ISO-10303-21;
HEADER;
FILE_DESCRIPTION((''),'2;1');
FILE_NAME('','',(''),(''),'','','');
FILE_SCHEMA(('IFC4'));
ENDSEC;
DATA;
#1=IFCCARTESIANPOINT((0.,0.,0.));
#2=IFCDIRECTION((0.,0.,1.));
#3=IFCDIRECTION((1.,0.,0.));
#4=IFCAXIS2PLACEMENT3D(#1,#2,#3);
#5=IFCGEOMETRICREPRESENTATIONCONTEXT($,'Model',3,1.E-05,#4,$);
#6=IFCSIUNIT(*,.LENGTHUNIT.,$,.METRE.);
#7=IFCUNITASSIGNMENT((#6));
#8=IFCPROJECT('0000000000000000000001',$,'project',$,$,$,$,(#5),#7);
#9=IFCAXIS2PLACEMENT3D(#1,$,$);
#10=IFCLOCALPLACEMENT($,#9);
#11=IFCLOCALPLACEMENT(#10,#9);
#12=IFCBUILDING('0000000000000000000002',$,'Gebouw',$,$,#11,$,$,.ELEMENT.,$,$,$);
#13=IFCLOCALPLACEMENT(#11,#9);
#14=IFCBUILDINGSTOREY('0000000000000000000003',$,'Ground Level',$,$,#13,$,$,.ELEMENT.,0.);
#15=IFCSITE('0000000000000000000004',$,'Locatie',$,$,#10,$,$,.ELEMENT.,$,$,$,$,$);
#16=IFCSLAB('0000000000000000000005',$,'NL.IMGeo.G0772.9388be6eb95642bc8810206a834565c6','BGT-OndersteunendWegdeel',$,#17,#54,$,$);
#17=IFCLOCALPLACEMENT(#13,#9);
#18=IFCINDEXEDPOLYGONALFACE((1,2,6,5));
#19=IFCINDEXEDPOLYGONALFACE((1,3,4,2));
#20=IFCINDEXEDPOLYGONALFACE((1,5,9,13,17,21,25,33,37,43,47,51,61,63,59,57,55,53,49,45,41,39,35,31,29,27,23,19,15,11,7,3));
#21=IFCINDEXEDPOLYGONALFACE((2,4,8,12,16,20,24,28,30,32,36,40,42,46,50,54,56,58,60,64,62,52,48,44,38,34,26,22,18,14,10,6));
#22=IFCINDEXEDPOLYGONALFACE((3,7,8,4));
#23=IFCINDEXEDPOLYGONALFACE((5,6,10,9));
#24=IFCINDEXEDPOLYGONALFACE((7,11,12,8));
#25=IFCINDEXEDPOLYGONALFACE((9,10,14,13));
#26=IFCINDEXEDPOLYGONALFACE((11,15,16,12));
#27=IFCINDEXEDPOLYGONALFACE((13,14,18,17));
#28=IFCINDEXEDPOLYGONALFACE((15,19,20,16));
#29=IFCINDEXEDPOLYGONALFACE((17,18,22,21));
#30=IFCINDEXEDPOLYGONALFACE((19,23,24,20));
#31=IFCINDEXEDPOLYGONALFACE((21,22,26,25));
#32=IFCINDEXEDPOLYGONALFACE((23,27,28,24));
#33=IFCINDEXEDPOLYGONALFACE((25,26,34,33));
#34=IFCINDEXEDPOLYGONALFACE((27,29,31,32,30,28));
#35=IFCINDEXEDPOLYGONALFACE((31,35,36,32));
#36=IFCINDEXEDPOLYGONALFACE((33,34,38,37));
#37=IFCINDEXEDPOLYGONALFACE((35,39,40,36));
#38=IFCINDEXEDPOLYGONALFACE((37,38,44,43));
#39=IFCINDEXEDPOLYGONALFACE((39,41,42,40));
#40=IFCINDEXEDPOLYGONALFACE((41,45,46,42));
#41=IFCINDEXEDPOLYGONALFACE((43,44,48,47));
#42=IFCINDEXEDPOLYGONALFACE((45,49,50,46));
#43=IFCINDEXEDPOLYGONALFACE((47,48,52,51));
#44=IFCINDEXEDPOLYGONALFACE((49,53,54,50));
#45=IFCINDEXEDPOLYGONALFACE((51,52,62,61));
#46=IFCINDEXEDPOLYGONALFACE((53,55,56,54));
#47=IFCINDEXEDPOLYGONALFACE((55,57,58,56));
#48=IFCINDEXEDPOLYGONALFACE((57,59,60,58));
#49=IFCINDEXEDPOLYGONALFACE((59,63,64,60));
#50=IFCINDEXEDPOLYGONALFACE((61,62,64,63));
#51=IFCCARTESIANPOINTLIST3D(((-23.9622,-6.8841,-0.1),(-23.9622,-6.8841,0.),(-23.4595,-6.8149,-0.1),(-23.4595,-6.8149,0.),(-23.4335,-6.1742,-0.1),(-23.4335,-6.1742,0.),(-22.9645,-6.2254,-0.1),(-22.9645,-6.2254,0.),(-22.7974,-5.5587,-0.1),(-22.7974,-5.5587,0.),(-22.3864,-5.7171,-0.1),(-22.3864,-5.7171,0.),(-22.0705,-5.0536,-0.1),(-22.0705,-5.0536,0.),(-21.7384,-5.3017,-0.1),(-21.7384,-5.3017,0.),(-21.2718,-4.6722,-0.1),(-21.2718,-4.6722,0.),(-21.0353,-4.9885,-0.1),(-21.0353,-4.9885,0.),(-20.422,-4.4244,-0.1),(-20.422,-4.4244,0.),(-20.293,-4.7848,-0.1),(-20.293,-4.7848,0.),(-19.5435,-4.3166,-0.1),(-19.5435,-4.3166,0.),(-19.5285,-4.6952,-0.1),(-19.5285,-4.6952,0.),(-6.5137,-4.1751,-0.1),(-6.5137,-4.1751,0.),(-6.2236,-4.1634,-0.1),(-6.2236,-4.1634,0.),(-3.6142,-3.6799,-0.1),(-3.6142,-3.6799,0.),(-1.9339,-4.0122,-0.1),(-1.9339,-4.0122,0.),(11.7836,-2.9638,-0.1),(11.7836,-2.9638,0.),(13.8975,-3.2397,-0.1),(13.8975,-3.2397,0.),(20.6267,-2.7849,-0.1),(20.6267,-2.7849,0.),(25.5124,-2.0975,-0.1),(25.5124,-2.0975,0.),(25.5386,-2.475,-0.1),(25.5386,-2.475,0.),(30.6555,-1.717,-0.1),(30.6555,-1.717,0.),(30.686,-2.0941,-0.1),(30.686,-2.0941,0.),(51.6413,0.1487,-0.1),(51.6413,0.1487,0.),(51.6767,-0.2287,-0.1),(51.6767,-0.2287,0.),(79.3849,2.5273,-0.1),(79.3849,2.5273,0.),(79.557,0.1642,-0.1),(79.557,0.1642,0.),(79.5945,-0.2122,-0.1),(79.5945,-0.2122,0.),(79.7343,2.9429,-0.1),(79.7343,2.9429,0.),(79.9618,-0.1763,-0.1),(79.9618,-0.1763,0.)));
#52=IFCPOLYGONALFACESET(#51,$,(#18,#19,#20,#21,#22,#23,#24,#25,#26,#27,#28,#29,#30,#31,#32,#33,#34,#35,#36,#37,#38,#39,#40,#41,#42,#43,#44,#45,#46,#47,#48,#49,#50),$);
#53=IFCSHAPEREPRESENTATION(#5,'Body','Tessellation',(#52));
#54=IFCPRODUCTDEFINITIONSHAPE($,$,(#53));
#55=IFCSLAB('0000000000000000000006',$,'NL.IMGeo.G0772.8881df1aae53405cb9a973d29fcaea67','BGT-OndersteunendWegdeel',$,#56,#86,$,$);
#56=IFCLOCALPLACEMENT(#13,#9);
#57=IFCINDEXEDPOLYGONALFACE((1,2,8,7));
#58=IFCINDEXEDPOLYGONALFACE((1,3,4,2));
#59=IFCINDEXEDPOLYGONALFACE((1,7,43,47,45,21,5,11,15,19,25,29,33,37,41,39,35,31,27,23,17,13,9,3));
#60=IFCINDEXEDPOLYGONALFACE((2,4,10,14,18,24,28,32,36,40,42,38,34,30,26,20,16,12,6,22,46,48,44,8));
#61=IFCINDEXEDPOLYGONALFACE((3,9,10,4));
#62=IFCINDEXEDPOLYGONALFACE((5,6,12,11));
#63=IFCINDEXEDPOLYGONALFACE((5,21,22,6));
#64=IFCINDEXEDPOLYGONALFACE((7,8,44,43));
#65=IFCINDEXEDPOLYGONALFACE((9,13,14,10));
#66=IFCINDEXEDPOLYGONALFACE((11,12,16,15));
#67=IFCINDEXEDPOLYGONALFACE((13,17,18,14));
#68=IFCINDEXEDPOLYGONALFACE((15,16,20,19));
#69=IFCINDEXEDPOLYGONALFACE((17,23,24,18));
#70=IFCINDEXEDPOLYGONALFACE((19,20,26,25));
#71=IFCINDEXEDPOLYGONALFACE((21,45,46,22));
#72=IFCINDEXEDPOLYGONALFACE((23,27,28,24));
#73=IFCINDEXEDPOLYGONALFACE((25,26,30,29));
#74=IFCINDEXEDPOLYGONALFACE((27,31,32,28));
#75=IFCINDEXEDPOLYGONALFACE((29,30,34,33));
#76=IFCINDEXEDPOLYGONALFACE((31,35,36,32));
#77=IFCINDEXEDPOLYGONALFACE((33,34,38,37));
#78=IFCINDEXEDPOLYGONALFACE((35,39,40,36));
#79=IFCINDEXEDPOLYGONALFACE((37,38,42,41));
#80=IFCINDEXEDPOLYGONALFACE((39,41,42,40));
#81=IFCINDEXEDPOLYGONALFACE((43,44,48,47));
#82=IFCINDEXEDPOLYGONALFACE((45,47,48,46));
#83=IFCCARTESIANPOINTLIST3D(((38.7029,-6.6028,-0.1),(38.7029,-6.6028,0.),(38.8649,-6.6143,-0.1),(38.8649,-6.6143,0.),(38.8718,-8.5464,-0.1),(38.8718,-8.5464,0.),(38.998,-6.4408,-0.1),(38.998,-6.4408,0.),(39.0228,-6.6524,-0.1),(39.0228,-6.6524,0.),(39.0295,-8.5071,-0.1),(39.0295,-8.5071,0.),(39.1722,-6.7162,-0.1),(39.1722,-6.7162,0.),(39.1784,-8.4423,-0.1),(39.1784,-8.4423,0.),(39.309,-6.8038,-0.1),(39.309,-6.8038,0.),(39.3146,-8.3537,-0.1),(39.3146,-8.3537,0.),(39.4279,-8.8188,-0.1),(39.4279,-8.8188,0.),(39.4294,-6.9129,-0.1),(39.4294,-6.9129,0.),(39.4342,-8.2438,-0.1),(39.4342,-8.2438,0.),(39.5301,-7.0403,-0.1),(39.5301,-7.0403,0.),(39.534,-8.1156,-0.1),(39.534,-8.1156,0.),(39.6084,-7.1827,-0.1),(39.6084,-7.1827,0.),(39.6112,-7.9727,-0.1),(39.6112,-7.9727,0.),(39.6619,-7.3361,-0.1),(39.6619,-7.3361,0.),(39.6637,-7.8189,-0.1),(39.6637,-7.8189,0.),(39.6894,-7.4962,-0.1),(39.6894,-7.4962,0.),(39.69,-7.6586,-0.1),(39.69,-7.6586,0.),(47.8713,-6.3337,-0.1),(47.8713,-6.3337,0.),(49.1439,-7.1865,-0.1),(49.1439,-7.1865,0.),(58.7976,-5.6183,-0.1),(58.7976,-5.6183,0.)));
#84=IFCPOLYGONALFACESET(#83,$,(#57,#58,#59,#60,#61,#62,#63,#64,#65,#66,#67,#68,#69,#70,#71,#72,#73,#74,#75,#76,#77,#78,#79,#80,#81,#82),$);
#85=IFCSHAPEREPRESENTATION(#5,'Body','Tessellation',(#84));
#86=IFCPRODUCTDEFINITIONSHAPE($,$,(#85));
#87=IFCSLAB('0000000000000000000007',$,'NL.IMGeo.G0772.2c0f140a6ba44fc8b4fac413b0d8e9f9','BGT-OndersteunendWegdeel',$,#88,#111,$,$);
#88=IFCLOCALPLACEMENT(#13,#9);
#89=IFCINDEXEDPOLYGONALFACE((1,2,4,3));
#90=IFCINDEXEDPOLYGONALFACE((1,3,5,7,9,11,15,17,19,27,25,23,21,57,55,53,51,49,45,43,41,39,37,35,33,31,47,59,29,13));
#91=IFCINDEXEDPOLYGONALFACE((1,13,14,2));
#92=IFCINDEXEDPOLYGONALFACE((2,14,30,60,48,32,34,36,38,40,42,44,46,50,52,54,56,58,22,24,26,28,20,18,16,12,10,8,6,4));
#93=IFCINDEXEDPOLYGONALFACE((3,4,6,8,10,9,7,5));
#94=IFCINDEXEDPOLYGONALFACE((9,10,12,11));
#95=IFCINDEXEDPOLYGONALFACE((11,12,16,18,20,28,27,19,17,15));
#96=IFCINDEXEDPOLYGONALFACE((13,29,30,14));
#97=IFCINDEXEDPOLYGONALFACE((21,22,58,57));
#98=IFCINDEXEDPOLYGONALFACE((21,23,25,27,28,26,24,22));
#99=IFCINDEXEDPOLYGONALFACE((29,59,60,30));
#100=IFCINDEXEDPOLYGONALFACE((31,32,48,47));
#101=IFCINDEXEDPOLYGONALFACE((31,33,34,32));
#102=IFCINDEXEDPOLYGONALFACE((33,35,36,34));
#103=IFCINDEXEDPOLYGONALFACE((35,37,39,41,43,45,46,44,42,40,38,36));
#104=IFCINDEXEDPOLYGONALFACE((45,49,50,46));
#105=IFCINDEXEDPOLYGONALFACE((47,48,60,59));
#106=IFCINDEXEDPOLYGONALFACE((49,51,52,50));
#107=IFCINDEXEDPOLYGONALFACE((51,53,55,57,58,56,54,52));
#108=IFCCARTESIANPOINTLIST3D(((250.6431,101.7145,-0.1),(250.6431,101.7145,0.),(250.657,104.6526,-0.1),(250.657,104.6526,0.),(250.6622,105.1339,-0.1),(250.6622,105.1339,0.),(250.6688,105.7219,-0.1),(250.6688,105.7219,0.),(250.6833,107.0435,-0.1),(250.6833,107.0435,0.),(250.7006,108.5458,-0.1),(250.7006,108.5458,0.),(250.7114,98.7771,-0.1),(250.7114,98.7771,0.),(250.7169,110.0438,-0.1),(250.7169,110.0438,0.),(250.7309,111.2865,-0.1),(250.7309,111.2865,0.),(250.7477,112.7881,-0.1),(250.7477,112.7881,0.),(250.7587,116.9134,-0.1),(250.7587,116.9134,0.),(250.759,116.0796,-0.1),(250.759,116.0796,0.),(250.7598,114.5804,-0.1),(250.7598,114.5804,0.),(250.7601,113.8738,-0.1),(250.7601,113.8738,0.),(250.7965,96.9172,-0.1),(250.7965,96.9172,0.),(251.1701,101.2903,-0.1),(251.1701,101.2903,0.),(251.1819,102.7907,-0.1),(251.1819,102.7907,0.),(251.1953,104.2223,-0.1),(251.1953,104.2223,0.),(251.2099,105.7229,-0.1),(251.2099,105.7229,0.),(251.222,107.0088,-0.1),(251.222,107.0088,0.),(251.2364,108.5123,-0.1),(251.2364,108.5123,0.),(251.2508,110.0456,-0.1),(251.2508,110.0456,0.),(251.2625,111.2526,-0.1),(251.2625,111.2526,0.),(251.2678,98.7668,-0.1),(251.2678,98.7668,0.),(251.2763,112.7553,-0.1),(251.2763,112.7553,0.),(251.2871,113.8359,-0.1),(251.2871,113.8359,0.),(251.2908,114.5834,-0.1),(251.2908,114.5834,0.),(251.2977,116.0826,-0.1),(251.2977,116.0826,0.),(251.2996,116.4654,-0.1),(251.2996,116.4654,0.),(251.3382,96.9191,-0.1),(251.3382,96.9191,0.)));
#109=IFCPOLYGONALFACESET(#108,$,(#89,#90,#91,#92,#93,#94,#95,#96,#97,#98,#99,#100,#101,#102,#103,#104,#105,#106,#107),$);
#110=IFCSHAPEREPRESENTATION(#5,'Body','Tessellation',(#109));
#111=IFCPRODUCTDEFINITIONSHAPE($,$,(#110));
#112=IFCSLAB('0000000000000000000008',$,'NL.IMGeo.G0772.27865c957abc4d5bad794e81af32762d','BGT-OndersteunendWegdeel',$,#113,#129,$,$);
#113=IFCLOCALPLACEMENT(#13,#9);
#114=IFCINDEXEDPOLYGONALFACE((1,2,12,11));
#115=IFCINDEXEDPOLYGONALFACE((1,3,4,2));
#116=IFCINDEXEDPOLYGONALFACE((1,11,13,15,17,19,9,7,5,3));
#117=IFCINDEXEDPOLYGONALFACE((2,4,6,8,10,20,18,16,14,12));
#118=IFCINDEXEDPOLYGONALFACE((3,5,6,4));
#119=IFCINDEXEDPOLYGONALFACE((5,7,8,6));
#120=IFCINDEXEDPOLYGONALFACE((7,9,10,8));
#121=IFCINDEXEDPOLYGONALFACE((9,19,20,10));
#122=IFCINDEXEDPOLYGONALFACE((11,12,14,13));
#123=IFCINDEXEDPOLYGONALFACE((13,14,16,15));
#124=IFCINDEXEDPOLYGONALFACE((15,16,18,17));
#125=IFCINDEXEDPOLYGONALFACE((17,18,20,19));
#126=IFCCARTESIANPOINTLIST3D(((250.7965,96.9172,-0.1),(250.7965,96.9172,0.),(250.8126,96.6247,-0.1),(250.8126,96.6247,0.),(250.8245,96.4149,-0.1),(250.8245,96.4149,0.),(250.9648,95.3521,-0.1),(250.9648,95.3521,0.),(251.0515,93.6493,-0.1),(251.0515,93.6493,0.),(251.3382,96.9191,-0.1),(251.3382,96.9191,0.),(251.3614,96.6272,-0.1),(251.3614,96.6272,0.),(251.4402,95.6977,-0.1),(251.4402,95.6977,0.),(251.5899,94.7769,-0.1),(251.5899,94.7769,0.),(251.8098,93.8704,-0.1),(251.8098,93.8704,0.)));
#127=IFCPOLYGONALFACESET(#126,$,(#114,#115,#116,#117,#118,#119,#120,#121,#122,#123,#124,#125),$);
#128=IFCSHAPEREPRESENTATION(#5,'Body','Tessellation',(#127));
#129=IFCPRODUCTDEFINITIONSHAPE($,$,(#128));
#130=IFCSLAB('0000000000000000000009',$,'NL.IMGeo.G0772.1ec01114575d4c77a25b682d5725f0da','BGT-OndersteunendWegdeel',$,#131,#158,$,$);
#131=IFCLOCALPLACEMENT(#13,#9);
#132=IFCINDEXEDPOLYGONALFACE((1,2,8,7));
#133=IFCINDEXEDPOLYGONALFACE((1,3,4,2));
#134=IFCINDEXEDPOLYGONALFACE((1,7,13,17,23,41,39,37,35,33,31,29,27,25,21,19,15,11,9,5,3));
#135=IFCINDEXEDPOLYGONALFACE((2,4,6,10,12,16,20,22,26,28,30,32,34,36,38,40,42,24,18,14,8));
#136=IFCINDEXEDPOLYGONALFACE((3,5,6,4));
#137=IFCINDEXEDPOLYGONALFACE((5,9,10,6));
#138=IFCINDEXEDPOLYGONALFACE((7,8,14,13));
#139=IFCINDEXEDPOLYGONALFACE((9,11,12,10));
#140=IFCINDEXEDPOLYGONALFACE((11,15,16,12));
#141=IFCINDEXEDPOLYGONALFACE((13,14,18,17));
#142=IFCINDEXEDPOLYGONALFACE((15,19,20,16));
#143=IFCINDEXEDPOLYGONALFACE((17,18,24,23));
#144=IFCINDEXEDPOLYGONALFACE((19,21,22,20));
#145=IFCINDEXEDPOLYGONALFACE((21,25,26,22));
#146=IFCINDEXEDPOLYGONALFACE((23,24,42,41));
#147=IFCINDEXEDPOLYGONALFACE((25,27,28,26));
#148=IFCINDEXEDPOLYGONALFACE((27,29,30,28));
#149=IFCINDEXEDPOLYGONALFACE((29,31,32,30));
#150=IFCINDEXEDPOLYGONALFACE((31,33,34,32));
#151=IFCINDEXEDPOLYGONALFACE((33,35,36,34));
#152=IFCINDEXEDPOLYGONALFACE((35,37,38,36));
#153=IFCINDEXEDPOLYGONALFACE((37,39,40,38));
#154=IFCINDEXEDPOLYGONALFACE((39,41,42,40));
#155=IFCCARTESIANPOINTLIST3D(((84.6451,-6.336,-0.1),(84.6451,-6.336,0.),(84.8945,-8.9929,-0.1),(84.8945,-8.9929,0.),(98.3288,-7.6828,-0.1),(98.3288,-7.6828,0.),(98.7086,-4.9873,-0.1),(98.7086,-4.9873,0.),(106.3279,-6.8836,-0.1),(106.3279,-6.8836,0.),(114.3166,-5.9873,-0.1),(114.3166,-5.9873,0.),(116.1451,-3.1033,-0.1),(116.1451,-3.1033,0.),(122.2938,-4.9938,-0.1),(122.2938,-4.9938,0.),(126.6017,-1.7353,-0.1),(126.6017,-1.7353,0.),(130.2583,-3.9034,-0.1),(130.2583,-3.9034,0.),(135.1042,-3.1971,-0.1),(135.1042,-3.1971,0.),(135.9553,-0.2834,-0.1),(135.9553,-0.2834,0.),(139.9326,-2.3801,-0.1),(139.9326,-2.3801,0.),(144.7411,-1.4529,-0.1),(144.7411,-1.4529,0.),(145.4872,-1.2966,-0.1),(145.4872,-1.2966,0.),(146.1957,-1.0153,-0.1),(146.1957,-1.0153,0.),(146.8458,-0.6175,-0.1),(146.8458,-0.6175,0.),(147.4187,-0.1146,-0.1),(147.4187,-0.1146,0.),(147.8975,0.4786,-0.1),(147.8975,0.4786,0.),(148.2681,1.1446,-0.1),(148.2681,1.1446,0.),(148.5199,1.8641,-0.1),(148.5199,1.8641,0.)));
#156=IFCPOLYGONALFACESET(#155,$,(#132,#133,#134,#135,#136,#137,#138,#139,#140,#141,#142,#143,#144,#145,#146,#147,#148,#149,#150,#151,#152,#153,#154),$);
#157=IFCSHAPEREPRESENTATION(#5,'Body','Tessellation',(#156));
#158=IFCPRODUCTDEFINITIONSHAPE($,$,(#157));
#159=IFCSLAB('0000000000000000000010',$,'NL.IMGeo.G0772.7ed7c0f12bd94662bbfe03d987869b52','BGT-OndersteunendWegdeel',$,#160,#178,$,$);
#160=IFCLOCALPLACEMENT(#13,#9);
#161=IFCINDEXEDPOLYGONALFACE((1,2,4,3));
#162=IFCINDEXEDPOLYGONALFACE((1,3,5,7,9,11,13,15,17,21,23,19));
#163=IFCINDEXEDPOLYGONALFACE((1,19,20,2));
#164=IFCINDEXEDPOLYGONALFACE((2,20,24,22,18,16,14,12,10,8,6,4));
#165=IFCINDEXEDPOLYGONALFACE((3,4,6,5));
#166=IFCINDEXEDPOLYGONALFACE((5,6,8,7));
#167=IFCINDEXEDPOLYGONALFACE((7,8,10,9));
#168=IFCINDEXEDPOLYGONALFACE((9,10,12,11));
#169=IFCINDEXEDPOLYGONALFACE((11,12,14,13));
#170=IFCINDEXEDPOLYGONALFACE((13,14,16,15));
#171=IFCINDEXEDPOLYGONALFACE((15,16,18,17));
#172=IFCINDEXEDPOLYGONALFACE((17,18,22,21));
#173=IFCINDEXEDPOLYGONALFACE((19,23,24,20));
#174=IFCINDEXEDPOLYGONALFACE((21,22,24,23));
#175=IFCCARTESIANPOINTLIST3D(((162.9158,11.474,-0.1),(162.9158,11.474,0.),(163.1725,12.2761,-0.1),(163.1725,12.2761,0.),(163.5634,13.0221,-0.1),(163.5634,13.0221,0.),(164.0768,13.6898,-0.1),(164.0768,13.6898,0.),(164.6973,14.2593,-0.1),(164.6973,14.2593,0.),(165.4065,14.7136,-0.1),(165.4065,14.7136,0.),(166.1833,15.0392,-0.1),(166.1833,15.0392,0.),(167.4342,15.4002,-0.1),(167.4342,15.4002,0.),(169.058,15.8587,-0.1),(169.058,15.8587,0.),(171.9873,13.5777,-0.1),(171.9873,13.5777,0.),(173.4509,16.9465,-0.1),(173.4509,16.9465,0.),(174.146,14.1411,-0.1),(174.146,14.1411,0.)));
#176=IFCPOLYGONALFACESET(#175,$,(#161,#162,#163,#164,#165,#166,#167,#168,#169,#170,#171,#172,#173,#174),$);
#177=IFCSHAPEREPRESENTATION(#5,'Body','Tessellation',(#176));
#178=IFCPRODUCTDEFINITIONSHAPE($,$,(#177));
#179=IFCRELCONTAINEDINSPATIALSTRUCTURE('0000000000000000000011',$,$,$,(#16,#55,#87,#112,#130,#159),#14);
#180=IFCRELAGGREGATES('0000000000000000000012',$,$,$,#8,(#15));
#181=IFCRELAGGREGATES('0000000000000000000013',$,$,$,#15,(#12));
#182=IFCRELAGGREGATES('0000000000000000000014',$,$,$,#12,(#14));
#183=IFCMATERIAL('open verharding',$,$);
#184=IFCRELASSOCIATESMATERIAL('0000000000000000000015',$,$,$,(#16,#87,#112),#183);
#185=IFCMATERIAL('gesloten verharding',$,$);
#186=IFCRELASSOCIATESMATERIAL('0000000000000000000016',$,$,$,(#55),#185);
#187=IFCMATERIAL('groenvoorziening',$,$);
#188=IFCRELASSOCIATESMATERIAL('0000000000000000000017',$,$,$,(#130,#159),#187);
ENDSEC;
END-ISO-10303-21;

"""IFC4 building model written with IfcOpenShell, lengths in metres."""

from ifc_helpers import new_model, si_unit, frame, origin, origin_with_axes, place, context, project, spatial, polyline, outline, extrude, material, element, save


model = new_model("IFC4")

# Units and contexts
model_context = context("Model", 3, precision=1e-05, world=origin_with_axes())
ifc_project = project(units=[si_unit("LENGTHUNIT", "METRE")], contexts=[model_context])

# Site, building, storey
site_placement = place(None, origin())
site = spatial("IfcSite", under=ifc_project, at=site_placement, Name="Locatie", CompositionType="ELEMENT")
building_placement = place(site_placement, origin())
building = spatial("IfcBuilding", under=site, at=building_placement, Name="Gebouw", CompositionType="ELEMENT")
storey_placement = place(building_placement, origin())
storey = spatial("IfcBuildingStorey", under=building, at=storey_placement, Name="Ground Level", CompositionType="ELEMENT", Elevation=0.0)

# Slabs
ifc_material_1 = material(Name="open verharding")
ifc_material_2 = material(Name="groenvoorziening")
slab_1_placement = place(storey_placement, origin())
element("IfcSlab", 1, at=slab_1_placement, inside=storey, material=ifc_material_1, Name="NL.IMGeo.G0772.9388be6eb95642bc8810206a834565c6", Description="BGT-OndersteunendWegdeel", context=model_context, shape_type="SweptSolid", body=[
    extrude(outline(polyline([(51.6413, 0.1487), (79.7343, 2.9429), (79.9618, -0.1763), (79.5945, -0.2122), (79.557, 0.1642), (79.3849, 2.5273), (51.6767, -0.2287), (30.686, -2.0941), (25.5386, -2.475), (20.6267, -2.7849), (13.8975, -3.2397), (-1.9339, -4.0122), (-6.2236, -4.1634), (-6.5137, -4.1751), (-19.5285, -4.6952), (-20.293, -4.7848), (-21.0353, -4.9885), (-21.7384, -5.3017), (-22.3864, -5.7171), (-22.9645, -6.2254), (-23.4595, -6.8149), (-23.9622, -6.8841), (-23.4335, -6.1742), (-22.7974, -5.5587), (-22.0705, -5.0536), (-21.2718, -4.6722), (-20.422, -4.4244), (-19.5435, -4.3166), (-3.6142, -3.6799), (11.7836, -2.9638), (25.5124, -2.0975), (30.6555, -1.717), (51.6413, 0.1487)])), frame((0.0, 0.0, -0.1), z_axis=(0.0, 0.0, 1.0), x_axis=(1.0, 0.0, 0.0)), (0.0, 0.0, 1.0), 0.1),
])
ifc_material_3 = material(Name="gesloten verharding")
slab_2_placement = place(storey_placement, origin())
element("IfcSlab", 2, at=slab_2_placement, inside=storey, material=ifc_material_3, Name="NL.IMGeo.G0772.8881df1aae53405cb9a973d29fcaea67", Description="BGT-OndersteunendWegdeel", context=model_context, shape_type="SweptSolid", body=[
    extrude(outline(polyline([(38.998, -6.4408), (47.8713, -6.3337), (58.7976, -5.6183), (49.1439, -7.1865), (39.4279, -8.8188), (38.8718, -8.5464), (39.0295, -8.5071), (39.1784, -8.4423), (39.3146, -8.3537), (39.4342, -8.2438), (39.534, -8.1156), (39.6112, -7.9727), (39.6637, -7.8189), (39.69, -7.6586), (39.6894, -7.4962), (39.6619, -7.3361), (39.6084, -7.1827), (39.5301, -7.0403), (39.4294, -6.9129), (39.309, -6.8038), (39.1722, -6.7162), (39.0228, -6.6524), (38.8649, -6.6143), (38.7029, -6.6028), (38.998, -6.4408)])), frame((0.0, 0.0, -0.1), z_axis=(0.0, 0.0, 1.0), x_axis=(1.0, 0.0, 0.0)), (0.0, 0.0, 1.0), 0.1),
])
slab_3_placement = place(storey_placement, origin())
element("IfcSlab", 3, at=slab_3_placement, inside=storey, material=ifc_material_1, Name="NL.IMGeo.G0772.2c0f140a6ba44fc8b4fac413b0d8e9f9", Description="BGT-OndersteunendWegdeel", context=model_context, shape_type="SweptSolid", body=[
    extrude(outline(polyline([(251.2977, 116.0826), (251.2908, 114.5834), (251.2871, 113.8359), (251.2763, 112.7553), (251.2625, 111.2526), (251.2508, 110.0456), (251.2364, 108.5123), (251.222, 107.0088), (251.2099, 105.7229), (251.1953, 104.2223), (251.1819, 102.7907), (251.1701, 101.2903), (251.2678, 98.7668), (251.3382, 96.9191), (250.7965, 96.9172), (250.7114, 98.7771), (250.6431, 101.7145), (250.657, 104.6526), (250.6622, 105.1339), (250.6688, 105.7219), (250.6833, 107.0435), (250.7006, 108.5458), (250.7169, 110.0438), (250.7309, 111.2865), (250.7477, 112.7881), (250.7601, 113.8738), (250.7598, 114.5804), (250.759, 116.0796), (250.7587, 116.9134), (251.2996, 116.4654), (251.2977, 116.0826)])), frame((0.0, 0.0, -0.1), z_axis=(0.0, 0.0, 1.0), x_axis=(1.0, 0.0, 0.0)), (0.0, 0.0, 1.0), 0.1),
])
slab_4_placement = place(storey_placement, origin())
element("IfcSlab", 4, at=slab_4_placement, inside=storey, material=ifc_material_1, Name="NL.IMGeo.G0772.27865c957abc4d5bad794e81af32762d", Description="BGT-OndersteunendWegdeel", context=model_context, shape_type="SweptSolid", body=[
    extrude(outline(polyline([(251.4402, 95.6977), (251.5899, 94.7769), (251.8098, 93.8704), (251.0515, 93.6493), (250.9648, 95.3521), (250.8245, 96.4149), (250.8126, 96.6247), (250.7965, 96.9172), (251.3382, 96.9191), (251.3614, 96.6272), (251.4402, 95.6977)])), frame((0.0, 0.0, -0.1), z_axis=(0.0, 0.0, 1.0), x_axis=(1.0, 0.0, 0.0)), (0.0, 0.0, 1.0), 0.1),
])
slab_5_placement = place(storey_placement, origin())
element("IfcSlab", 5, at=slab_5_placement, inside=storey, material=ifc_material_2, Name="NL.IMGeo.G0772.1ec01114575d4c77a25b682d5725f0da", Description="BGT-OndersteunendWegdeel", context=model_context, shape_type="SweptSolid", body=[
    extrude(outline(polyline([(126.6017, -1.7353), (135.9553, -0.2834), (148.5199, 1.8641), (148.2681, 1.1446), (147.8975, 0.4786), (147.4187, -0.1146), (146.8458, -0.6175), (146.1957, -1.0153), (145.4872, -1.2966), (144.7411, -1.4529), (139.9326, -2.3801), (135.1042, -3.1971), (130.2583, -3.9034), (122.2938, -4.9938), (114.3166, -5.9873), (106.3279, -6.8836), (98.3288, -7.6828), (84.8945, -8.9929), (84.6451, -6.336), (98.7086, -4.9873), (116.1451, -3.1033), (126.6017, -1.7353)])), frame((0.0, 0.0, -0.1), z_axis=(0.0, 0.0, 1.0), x_axis=(1.0, 0.0, 0.0)), (0.0, 0.0, 1.0), 0.1),
])
slab_6_placement = place(storey_placement, origin())
element("IfcSlab", 6, at=slab_6_placement, inside=storey, material=ifc_material_2, Name="NL.IMGeo.G0772.7ed7c0f12bd94662bbfe03d987869b52", Description="BGT-OndersteunendWegdeel", context=model_context, shape_type="SweptSolid", body=[
    extrude(outline(polyline([(163.1725, 12.2761), (163.5634, 13.0221), (164.0768, 13.6898), (164.6973, 14.2593), (165.4065, 14.7136), (166.1833, 15.0392), (167.4342, 15.4002), (169.058, 15.8587), (173.4509, 16.9465), (174.146, 14.1411), (171.9873, 13.5777), (162.9158, 11.474), (163.1725, 12.2761)])), frame((0.0, 0.0, -0.1), z_axis=(0.0, 0.0, 1.0), x_axis=(1.0, 0.0, 0.0)), (0.0, 0.0, 1.0), 0.1),
])

save(model, "model.ifc")
